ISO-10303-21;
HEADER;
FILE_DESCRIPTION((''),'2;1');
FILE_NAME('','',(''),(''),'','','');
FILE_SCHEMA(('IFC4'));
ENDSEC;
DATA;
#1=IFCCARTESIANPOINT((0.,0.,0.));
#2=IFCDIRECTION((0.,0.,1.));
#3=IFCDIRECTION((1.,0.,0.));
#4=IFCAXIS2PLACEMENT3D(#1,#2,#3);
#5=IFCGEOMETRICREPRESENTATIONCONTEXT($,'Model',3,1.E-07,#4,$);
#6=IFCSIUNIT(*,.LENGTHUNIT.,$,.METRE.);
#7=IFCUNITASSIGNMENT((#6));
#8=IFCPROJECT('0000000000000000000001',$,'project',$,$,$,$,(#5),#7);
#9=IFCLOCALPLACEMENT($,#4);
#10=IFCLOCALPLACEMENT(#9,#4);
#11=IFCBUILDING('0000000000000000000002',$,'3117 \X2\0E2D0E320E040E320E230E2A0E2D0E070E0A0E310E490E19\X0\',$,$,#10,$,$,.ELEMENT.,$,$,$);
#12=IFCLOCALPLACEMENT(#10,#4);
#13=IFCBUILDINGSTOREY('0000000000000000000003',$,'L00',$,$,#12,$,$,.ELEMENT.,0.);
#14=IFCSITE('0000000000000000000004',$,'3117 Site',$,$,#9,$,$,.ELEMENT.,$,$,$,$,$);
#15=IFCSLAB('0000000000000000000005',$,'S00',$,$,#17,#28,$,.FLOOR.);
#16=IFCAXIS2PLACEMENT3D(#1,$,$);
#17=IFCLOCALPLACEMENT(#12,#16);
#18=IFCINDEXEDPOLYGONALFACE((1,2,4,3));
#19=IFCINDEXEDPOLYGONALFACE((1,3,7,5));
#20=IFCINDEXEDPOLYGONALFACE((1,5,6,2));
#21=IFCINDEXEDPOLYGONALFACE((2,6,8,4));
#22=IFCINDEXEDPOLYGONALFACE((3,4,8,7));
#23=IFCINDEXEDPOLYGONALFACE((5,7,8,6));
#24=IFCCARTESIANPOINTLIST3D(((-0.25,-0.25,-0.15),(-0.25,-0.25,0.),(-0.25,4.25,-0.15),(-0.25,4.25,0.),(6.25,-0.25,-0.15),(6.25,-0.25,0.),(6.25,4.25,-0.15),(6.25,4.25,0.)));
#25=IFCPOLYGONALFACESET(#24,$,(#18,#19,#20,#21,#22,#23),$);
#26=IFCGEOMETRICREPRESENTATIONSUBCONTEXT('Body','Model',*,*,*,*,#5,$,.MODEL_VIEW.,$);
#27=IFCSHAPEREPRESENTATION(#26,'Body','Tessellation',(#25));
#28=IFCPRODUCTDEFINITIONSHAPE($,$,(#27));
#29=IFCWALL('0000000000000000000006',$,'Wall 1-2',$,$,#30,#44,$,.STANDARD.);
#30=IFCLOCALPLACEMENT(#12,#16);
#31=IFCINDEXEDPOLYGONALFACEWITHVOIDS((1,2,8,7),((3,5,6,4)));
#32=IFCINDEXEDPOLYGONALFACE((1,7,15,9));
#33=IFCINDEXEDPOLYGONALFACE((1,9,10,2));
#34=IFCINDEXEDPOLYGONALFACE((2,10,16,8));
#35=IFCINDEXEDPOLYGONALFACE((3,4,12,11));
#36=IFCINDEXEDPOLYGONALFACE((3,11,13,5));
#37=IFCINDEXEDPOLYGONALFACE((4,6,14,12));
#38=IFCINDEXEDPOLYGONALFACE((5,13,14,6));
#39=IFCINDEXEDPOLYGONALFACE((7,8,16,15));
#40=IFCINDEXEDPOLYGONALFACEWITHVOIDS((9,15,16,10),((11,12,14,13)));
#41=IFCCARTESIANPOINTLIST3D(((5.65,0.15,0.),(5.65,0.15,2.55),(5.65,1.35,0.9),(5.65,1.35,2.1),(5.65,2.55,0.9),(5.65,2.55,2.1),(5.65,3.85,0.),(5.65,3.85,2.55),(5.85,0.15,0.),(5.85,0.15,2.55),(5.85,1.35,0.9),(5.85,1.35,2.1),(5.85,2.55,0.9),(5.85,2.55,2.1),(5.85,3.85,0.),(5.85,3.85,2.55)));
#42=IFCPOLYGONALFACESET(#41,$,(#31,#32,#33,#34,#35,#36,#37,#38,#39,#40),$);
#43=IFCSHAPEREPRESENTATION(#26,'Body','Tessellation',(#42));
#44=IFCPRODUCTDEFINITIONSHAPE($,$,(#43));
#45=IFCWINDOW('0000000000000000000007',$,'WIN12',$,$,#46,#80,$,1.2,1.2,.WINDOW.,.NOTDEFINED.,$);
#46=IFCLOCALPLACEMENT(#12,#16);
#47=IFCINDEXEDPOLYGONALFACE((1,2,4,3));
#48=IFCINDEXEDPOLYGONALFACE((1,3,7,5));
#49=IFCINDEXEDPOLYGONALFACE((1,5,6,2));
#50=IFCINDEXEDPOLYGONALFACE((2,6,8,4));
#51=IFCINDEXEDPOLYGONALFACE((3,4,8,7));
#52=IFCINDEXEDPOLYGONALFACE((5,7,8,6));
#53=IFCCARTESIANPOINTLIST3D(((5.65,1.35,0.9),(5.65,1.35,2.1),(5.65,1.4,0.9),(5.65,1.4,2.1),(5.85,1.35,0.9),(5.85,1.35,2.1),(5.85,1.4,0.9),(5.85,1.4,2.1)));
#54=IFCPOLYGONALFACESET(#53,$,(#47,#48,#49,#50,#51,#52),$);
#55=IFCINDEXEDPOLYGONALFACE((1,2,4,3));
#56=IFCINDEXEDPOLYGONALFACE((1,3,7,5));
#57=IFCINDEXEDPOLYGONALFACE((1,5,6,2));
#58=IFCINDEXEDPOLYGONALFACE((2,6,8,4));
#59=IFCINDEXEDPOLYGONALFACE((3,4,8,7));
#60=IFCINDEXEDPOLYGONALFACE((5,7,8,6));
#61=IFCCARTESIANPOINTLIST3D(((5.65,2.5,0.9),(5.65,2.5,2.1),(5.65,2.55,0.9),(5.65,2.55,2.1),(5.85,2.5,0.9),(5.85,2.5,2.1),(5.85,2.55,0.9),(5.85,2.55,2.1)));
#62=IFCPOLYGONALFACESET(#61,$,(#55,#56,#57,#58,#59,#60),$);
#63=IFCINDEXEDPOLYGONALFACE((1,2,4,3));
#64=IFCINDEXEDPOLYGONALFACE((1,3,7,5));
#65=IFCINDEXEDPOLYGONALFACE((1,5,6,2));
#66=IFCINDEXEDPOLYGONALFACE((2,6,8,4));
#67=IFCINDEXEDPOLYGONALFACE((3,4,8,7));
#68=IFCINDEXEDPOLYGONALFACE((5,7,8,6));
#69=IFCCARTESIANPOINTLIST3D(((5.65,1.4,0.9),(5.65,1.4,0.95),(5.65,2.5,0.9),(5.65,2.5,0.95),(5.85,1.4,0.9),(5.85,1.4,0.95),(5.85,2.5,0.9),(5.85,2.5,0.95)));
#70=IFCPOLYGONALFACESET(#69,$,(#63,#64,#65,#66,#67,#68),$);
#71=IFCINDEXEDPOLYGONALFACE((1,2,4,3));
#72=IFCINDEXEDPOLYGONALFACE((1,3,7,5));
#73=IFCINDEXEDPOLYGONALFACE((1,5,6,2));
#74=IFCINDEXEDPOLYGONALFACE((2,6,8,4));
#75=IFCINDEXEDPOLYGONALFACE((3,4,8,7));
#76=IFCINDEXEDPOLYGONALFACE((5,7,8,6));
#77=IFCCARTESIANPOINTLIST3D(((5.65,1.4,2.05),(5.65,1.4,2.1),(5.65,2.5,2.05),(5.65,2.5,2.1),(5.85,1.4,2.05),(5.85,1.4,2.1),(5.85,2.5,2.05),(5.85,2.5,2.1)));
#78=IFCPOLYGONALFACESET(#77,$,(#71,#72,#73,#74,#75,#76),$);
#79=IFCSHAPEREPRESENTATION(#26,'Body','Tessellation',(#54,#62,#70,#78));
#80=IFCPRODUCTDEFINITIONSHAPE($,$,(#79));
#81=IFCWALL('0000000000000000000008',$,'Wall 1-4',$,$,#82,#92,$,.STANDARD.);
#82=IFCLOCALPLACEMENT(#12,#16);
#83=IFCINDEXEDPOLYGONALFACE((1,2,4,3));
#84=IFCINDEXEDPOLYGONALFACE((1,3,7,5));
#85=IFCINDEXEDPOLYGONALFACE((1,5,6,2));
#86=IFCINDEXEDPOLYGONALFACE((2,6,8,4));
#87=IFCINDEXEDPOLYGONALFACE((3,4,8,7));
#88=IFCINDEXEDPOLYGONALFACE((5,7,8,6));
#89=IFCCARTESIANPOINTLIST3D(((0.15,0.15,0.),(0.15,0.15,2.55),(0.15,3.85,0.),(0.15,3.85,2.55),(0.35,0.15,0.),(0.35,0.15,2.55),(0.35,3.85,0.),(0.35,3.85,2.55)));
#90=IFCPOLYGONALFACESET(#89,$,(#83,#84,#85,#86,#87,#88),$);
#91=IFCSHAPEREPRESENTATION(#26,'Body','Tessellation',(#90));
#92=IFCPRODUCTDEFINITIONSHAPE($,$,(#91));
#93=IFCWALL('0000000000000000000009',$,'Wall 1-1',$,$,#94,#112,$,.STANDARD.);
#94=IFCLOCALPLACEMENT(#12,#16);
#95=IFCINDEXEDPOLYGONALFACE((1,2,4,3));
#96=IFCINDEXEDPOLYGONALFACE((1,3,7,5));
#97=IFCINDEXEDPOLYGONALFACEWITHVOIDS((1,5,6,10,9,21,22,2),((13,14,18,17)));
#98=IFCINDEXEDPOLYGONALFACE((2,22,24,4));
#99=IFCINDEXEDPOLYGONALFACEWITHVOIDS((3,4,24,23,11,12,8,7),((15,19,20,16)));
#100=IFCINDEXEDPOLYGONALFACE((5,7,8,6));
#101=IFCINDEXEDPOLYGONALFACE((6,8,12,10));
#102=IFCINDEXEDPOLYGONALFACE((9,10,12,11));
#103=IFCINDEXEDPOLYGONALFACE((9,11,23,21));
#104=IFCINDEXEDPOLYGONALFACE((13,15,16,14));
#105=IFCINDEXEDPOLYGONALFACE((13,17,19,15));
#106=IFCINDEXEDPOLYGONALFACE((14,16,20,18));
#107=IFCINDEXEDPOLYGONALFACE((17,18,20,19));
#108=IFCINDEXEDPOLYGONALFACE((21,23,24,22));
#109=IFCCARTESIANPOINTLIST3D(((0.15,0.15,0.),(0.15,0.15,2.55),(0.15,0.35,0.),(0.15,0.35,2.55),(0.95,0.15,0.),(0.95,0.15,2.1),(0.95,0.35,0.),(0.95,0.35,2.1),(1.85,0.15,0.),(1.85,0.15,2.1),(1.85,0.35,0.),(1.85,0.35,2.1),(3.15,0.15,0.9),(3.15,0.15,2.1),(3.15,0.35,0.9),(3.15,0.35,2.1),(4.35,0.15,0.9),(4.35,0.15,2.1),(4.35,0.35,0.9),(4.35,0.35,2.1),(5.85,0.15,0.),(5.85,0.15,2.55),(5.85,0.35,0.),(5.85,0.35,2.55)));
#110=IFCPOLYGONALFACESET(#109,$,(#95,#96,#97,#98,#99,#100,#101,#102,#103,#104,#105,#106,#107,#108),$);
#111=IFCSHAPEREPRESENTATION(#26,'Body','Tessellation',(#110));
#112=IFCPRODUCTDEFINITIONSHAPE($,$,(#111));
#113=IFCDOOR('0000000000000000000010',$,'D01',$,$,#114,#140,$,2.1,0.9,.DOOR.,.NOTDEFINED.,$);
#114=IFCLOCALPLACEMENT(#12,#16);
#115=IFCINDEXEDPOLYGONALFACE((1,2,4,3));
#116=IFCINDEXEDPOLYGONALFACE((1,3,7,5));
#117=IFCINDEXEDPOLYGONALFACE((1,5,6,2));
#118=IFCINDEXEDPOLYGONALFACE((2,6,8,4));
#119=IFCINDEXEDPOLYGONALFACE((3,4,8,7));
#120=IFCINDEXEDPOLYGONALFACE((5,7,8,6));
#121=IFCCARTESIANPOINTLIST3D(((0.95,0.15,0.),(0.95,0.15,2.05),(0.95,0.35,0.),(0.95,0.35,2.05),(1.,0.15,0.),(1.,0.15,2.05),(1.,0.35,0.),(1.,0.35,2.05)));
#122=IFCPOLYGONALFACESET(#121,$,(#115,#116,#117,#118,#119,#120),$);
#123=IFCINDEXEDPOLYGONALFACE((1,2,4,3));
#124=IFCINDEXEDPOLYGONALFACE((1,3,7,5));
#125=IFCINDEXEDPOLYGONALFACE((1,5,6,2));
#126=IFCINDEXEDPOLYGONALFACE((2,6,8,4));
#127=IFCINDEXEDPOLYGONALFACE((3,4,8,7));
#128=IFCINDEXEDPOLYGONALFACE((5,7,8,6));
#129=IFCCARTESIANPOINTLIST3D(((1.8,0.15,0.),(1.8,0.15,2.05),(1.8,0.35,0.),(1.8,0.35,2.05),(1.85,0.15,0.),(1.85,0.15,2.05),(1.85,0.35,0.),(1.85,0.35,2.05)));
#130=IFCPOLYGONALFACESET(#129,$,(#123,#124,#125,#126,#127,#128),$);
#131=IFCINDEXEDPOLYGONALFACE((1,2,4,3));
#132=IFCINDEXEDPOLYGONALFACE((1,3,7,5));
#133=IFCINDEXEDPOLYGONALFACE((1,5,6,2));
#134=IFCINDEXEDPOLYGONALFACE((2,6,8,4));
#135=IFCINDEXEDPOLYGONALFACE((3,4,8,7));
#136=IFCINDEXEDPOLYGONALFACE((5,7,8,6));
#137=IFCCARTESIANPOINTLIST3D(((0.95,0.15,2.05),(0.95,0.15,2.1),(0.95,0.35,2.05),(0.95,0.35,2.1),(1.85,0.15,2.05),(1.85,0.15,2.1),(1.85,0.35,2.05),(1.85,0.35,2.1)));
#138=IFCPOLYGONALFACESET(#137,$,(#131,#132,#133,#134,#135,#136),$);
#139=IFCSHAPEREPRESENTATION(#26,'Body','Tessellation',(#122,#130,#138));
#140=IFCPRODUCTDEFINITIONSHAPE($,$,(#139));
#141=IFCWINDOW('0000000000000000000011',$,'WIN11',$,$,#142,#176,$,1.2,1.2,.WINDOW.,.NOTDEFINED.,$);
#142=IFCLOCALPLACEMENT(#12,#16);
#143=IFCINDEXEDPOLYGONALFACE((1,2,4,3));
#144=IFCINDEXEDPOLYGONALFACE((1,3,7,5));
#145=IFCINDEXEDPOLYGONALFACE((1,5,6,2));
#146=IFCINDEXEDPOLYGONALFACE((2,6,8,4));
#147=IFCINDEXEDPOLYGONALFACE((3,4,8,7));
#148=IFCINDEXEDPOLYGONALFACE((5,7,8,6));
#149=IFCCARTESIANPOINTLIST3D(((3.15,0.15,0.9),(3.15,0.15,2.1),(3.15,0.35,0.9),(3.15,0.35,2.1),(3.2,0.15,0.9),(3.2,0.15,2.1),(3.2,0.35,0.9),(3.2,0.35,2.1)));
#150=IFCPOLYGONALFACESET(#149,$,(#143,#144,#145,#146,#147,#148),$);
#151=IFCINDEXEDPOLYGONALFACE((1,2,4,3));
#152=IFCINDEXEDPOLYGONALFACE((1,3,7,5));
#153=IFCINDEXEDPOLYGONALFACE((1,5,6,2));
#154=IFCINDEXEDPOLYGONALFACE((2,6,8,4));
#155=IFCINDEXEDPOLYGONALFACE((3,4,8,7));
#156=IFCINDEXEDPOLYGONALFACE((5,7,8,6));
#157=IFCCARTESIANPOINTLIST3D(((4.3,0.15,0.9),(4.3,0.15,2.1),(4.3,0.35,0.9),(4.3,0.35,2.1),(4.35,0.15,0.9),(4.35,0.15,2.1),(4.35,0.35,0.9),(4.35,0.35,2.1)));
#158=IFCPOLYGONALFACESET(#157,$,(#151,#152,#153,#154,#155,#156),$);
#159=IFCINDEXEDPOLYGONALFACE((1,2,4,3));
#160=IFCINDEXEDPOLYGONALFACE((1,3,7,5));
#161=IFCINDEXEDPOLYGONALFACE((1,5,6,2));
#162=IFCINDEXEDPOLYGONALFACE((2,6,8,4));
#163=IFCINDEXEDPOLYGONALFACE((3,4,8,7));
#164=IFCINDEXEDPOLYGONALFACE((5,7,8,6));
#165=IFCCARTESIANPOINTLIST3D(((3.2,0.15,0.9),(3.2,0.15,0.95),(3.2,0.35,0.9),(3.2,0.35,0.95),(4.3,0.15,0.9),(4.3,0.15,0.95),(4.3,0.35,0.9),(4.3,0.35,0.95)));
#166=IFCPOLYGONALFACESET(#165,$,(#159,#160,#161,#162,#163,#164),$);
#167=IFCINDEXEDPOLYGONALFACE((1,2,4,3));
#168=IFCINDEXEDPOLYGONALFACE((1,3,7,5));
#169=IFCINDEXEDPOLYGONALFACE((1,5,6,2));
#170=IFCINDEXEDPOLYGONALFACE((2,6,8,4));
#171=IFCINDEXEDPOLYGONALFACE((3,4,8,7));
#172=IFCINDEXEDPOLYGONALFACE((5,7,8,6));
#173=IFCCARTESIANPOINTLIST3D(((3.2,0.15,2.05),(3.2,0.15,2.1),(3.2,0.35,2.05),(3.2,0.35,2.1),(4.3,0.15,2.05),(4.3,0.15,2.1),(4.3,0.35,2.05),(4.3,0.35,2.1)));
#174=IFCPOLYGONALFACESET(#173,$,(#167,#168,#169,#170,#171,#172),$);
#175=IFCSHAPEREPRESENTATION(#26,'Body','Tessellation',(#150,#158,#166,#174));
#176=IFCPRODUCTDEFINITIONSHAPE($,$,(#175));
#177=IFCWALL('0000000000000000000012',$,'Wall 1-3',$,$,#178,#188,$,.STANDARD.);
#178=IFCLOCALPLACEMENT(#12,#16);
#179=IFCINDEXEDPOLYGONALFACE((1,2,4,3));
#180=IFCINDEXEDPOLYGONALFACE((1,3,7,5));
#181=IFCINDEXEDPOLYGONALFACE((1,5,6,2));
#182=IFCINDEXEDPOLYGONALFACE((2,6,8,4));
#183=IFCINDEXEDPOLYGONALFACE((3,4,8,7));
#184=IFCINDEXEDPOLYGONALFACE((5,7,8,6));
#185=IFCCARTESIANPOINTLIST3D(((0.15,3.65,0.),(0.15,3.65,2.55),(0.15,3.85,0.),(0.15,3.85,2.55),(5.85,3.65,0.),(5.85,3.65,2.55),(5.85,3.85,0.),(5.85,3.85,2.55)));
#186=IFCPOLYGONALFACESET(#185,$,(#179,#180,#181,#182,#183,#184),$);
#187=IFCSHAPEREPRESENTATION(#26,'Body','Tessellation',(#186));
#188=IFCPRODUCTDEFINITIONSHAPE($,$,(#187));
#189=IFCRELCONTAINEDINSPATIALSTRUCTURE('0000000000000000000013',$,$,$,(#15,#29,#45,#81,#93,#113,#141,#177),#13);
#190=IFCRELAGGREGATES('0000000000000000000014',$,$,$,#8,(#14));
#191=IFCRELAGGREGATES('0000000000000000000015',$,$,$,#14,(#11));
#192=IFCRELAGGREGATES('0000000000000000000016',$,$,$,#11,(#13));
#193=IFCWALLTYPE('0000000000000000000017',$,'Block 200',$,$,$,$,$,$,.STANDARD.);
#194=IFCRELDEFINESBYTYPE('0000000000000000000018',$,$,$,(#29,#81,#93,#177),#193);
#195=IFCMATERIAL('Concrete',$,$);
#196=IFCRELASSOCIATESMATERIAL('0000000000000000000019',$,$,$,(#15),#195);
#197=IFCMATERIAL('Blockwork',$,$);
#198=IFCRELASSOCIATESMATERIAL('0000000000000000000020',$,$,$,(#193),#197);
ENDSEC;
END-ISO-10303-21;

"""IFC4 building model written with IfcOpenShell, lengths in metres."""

from ifc_helpers import new_model, si_unit, frame, origin_with_axes, place, context, subcontext, project, spatial, polyline, outline, extrude, material, type_object, element, fill, save


model = new_model("IFC4")

# Units and contexts
model_context = context("Model", 3, precision=1e-07, world=origin_with_axes())
body_context = subcontext(model_context, "Body", "Model", "MODEL_VIEW")
ifc_project = project(units=[si_unit("LENGTHUNIT", "METRE")], contexts=[model_context])

# Site, building, storey
site_placement = place(None, origin_with_axes())
site = spatial("IfcSite", under=ifc_project, at=site_placement, Name="3117 Site", CompositionType="ELEMENT")
building_placement = place(site_placement, origin_with_axes())
building = spatial("IfcBuilding", under=site, at=building_placement, Name="3117 อาคารสองชั้น", CompositionType="ELEMENT")
storey_placement = place(building_placement, origin_with_axes())
storey = spatial("IfcBuildingStorey", under=building, at=storey_placement, Name="L00", CompositionType="ELEMENT", Elevation=0.0)

# Slab
ifc_material_1 = material(Name="Concrete")
slab_placement = place(storey_placement, frame((0.0, 0.0, -0.15), z_axis=(0.0, 0.0, 1.0), x_axis=(1.0, 0.0, 0.0)))
element("IfcSlab", 1, at=slab_placement, inside=storey, material=ifc_material_1, Name="S00", PredefinedType="FLOOR", context=body_context, shape_type="SweptSolid", body=[
    extrude(outline(polyline([(-0.25, -0.25), (6.25, -0.25), (6.25, 4.25), (-0.25, 4.25), (-0.25, -0.25)])), origin_with_axes(), (0.0, 0.0, 1.0), 0.15),
])

# Wall, opening, window
ifc_material_2 = material(Name="Blockwork")
wall_type = type_object("IfcWallType", Name="Block 200", PredefinedType="STANDARD", material=ifc_material_2)
wall_1_placement = place(storey_placement, frame((5.85, 0.15, 0.0), z_axis=(0.0, 0.0, 1.0), x_axis=(0.0, 1.0, 0.0)))
wall_1 = element("IfcWall", 2, at=wall_1_placement, inside=storey, type_object=wall_type, Name="Wall 1-2", PredefinedType="STANDARD", context=body_context, shape_type="SweptSolid", body=[
    extrude(outline(polyline([(0.0, 0.0), (3.7, 0.0), (3.7, 0.2), (0.0, 0.2), (0.0, 0.0)])), origin_with_axes(), (0.0, 0.0, 1.0), 2.55),
])
opening_1_placement = place(wall_1_placement, frame((1.2, 0.0, 0.9), z_axis=(0.0, 0.0, 1.0), x_axis=(1.0, 0.0, 0.0)))
opening_1 = element("IfcOpeningElement", 3, at=opening_1_placement, cuts=wall_1, PredefinedType="OPENING", context=body_context, shape_type="SweptSolid", body=[
    extrude(outline(polyline([(0.0, 0.0), (1.2, 0.0), (1.2, 0.2), (0.0, 0.2), (0.0, 0.0)])), origin_with_axes(), (0.0, 0.0, 1.0), 1.2),
])
window_1_placement = place(opening_1_placement, frame((0.0, 0.0, 0.0), z_axis=(0.0, 0.0, 1.0), x_axis=(1.0, 0.0, 0.0)))
window_1 = element("IfcWindow", 4, at=window_1_placement, inside=storey, Name="WIN12", OverallHeight=1.2, OverallWidth=1.2, PartitioningType="NOTDEFINED", PredefinedType="WINDOW", context=body_context, shape_type="SweptSolid", body=[
    extrude(outline(polyline([(0.0, 0.0), (0.05, 0.0), (0.05, 0.2), (0.0, 0.2), (0.0, 0.0)])), origin_with_axes(), (0.0, 0.0, 1.0), 1.2),
    extrude(outline(polyline([(0.0, 0.0), (0.05, 0.0), (0.05, 0.2), (0.0, 0.2), (0.0, 0.0)])), frame((1.15, 0.0, 0.0), z_axis=(0.0, 0.0, 1.0), x_axis=(1.0, 0.0, 0.0)), (0.0, 0.0, 1.0), 1.2),
    extrude(outline(polyline([(0.0, 0.0), (1.1, 0.0), (1.1, 0.2), (0.0, 0.2), (0.0, 0.0)])), frame((0.05, 0.0, 0.0), z_axis=(0.0, 0.0, 1.0), x_axis=(1.0, 0.0, 0.0)), (0.0, 0.0, 1.0), 0.05),
    extrude(outline(polyline([(0.0, 0.0), (1.1, 0.0), (1.1, 0.2), (0.0, 0.2), (0.0, 0.0)])), frame((0.05, 0.0, 1.15), z_axis=(0.0, 0.0, 1.0), x_axis=(1.0, 0.0, 0.0)), (0.0, 0.0, 1.0), 0.05),
])
fill(opening_1, window_1)

# Wall
wall_2_placement = place(storey_placement, frame((0.15, 3.85, 0.0), z_axis=(0.0, 0.0, 1.0), x_axis=(0.0, -1.0, 0.0)))
element("IfcWall", 5, at=wall_2_placement, inside=storey, type_object=wall_type, Name="Wall 1-4", PredefinedType="STANDARD", context=body_context, shape_type="SweptSolid", body=[
    extrude(outline(polyline([(0.0, 0.0), (3.7, 0.0), (3.7, 0.2), (0.0, 0.2), (0.0, 0.0)])), origin_with_axes(), (0.0, 0.0, 1.0), 2.55),
])

# Wall, openings, door, window
wall_3_placement = place(storey_placement, frame((0.15, 0.15, 0.0), z_axis=(0.0, 0.0, 1.0), x_axis=(1.0, 0.0, 0.0)))
wall_3 = element("IfcWall", 6, at=wall_3_placement, inside=storey, type_object=wall_type, Name="Wall 1-1", PredefinedType="STANDARD", context=body_context, shape_type="SweptSolid", body=[
    extrude(outline(polyline([(0.0, 0.0), (5.7, 0.0), (5.7, 0.2), (0.0, 0.2), (0.0, 0.0)])), origin_with_axes(), (0.0, 0.0, 1.0), 2.55),
])
opening_2_placement = place(wall_3_placement, frame((0.8, 0.0, 0.0), z_axis=(0.0, 0.0, 1.0), x_axis=(1.0, 0.0, 0.0)))
opening_2 = element("IfcOpeningElement", 7, at=opening_2_placement, cuts=wall_3, PredefinedType="OPENING", context=body_context, shape_type="SweptSolid", body=[
    extrude(outline(polyline([(0.0, 0.0), (0.9, 0.0), (0.9, 0.2), (0.0, 0.2), (0.0, 0.0)])), origin_with_axes(), (0.0, 0.0, 1.0), 2.1),
])
opening_3_placement = place(wall_3_placement, frame((3.0, 0.0, 0.9), z_axis=(0.0, 0.0, 1.0), x_axis=(1.0, 0.0, 0.0)))
opening_3 = element("IfcOpeningElement", 8, at=opening_3_placement, cuts=wall_3, PredefinedType="OPENING", context=body_context, shape_type="SweptSolid", body=[
    extrude(outline(polyline([(0.0, 0.0), (1.2, 0.0), (1.2, 0.2), (0.0, 0.2), (0.0, 0.0)])), origin_with_axes(), (0.0, 0.0, 1.0), 1.2),
])
door_placement = place(opening_2_placement, frame((0.0, 0.0, 0.0), z_axis=(0.0, 0.0, 1.0), x_axis=(1.0, 0.0, 0.0)))
door = element("IfcDoor", 9, at=door_placement, inside=storey, Name="D01", OperationType="NOTDEFINED", OverallHeight=2.1, OverallWidth=0.9, PredefinedType="DOOR", context=body_context, shape_type="SweptSolid", body=[
    extrude(outline(polyline([(0.0, 0.0), (0.05, 0.0), (0.05, 0.2), (0.0, 0.2), (0.0, 0.0)])), origin_with_axes(), (0.0, 0.0, 1.0), 2.05),
    extrude(outline(polyline([(0.0, 0.0), (0.05, 0.0), (0.05, 0.2), (0.0, 0.2), (0.0, 0.0)])), frame((0.85, 0.0, 0.0), z_axis=(0.0, 0.0, 1.0), x_axis=(1.0, 0.0, 0.0)), (0.0, 0.0, 1.0), 2.05),
    extrude(outline(polyline([(0.0, 0.0), (0.9, 0.0), (0.9, 0.2), (0.0, 0.2), (0.0, 0.0)])), frame((0.0, 0.0, 2.05), z_axis=(0.0, 0.0, 1.0), x_axis=(1.0, 0.0, 0.0)), (0.0, 0.0, 1.0), 0.05),
])
fill(opening_2, door)
window_2_placement = place(opening_3_placement, frame((0.0, 0.0, 0.0), z_axis=(0.0, 0.0, 1.0), x_axis=(1.0, 0.0, 0.0)))
window_2 = element("IfcWindow", 10, at=window_2_placement, inside=storey, Name="WIN11", OverallHeight=1.2, OverallWidth=1.2, PartitioningType="NOTDEFINED", PredefinedType="WINDOW", context=body_context, shape_type="SweptSolid", body=[
    extrude(outline(polyline([(0.0, 0.0), (0.05, 0.0), (0.05, 0.2), (0.0, 0.2), (0.0, 0.0)])), origin_with_axes(), (0.0, 0.0, 1.0), 1.2),
    extrude(outline(polyline([(0.0, 0.0), (0.05, 0.0), (0.05, 0.2), (0.0, 0.2), (0.0, 0.0)])), frame((1.15, 0.0, 0.0), z_axis=(0.0, 0.0, 1.0), x_axis=(1.0, 0.0, 0.0)), (0.0, 0.0, 1.0), 1.2),
    extrude(outline(polyline([(0.0, 0.0), (1.1, 0.0), (1.1, 0.2), (0.0, 0.2), (0.0, 0.0)])), frame((0.05, 0.0, 0.0), z_axis=(0.0, 0.0, 1.0), x_axis=(1.0, 0.0, 0.0)), (0.0, 0.0, 1.0), 0.05),
    extrude(outline(polyline([(0.0, 0.0), (1.1, 0.0), (1.1, 0.2), (0.0, 0.2), (0.0, 0.0)])), frame((0.05, 0.0, 1.15), z_axis=(0.0, 0.0, 1.0), x_axis=(1.0, 0.0, 0.0)), (0.0, 0.0, 1.0), 0.05),
])
fill(opening_3, window_2)

# Wall
wall_4_placement = place(storey_placement, frame((5.85, 3.85, 0.0), z_axis=(0.0, 0.0, 1.0), x_axis=(-1.0, 0.0, 0.0)))
element("IfcWall", 11, at=wall_4_placement, inside=storey, type_object=wall_type, Name="Wall 1-3", PredefinedType="STANDARD", context=body_context, shape_type="SweptSolid", body=[
    extrude(outline(polyline([(0.0, 0.0), (5.7, 0.0), (5.7, 0.2), (0.0, 0.2), (0.0, 0.0)])), origin_with_axes(), (0.0, 0.0, 1.0), 2.55),
])

save(model, "model.ifc")
